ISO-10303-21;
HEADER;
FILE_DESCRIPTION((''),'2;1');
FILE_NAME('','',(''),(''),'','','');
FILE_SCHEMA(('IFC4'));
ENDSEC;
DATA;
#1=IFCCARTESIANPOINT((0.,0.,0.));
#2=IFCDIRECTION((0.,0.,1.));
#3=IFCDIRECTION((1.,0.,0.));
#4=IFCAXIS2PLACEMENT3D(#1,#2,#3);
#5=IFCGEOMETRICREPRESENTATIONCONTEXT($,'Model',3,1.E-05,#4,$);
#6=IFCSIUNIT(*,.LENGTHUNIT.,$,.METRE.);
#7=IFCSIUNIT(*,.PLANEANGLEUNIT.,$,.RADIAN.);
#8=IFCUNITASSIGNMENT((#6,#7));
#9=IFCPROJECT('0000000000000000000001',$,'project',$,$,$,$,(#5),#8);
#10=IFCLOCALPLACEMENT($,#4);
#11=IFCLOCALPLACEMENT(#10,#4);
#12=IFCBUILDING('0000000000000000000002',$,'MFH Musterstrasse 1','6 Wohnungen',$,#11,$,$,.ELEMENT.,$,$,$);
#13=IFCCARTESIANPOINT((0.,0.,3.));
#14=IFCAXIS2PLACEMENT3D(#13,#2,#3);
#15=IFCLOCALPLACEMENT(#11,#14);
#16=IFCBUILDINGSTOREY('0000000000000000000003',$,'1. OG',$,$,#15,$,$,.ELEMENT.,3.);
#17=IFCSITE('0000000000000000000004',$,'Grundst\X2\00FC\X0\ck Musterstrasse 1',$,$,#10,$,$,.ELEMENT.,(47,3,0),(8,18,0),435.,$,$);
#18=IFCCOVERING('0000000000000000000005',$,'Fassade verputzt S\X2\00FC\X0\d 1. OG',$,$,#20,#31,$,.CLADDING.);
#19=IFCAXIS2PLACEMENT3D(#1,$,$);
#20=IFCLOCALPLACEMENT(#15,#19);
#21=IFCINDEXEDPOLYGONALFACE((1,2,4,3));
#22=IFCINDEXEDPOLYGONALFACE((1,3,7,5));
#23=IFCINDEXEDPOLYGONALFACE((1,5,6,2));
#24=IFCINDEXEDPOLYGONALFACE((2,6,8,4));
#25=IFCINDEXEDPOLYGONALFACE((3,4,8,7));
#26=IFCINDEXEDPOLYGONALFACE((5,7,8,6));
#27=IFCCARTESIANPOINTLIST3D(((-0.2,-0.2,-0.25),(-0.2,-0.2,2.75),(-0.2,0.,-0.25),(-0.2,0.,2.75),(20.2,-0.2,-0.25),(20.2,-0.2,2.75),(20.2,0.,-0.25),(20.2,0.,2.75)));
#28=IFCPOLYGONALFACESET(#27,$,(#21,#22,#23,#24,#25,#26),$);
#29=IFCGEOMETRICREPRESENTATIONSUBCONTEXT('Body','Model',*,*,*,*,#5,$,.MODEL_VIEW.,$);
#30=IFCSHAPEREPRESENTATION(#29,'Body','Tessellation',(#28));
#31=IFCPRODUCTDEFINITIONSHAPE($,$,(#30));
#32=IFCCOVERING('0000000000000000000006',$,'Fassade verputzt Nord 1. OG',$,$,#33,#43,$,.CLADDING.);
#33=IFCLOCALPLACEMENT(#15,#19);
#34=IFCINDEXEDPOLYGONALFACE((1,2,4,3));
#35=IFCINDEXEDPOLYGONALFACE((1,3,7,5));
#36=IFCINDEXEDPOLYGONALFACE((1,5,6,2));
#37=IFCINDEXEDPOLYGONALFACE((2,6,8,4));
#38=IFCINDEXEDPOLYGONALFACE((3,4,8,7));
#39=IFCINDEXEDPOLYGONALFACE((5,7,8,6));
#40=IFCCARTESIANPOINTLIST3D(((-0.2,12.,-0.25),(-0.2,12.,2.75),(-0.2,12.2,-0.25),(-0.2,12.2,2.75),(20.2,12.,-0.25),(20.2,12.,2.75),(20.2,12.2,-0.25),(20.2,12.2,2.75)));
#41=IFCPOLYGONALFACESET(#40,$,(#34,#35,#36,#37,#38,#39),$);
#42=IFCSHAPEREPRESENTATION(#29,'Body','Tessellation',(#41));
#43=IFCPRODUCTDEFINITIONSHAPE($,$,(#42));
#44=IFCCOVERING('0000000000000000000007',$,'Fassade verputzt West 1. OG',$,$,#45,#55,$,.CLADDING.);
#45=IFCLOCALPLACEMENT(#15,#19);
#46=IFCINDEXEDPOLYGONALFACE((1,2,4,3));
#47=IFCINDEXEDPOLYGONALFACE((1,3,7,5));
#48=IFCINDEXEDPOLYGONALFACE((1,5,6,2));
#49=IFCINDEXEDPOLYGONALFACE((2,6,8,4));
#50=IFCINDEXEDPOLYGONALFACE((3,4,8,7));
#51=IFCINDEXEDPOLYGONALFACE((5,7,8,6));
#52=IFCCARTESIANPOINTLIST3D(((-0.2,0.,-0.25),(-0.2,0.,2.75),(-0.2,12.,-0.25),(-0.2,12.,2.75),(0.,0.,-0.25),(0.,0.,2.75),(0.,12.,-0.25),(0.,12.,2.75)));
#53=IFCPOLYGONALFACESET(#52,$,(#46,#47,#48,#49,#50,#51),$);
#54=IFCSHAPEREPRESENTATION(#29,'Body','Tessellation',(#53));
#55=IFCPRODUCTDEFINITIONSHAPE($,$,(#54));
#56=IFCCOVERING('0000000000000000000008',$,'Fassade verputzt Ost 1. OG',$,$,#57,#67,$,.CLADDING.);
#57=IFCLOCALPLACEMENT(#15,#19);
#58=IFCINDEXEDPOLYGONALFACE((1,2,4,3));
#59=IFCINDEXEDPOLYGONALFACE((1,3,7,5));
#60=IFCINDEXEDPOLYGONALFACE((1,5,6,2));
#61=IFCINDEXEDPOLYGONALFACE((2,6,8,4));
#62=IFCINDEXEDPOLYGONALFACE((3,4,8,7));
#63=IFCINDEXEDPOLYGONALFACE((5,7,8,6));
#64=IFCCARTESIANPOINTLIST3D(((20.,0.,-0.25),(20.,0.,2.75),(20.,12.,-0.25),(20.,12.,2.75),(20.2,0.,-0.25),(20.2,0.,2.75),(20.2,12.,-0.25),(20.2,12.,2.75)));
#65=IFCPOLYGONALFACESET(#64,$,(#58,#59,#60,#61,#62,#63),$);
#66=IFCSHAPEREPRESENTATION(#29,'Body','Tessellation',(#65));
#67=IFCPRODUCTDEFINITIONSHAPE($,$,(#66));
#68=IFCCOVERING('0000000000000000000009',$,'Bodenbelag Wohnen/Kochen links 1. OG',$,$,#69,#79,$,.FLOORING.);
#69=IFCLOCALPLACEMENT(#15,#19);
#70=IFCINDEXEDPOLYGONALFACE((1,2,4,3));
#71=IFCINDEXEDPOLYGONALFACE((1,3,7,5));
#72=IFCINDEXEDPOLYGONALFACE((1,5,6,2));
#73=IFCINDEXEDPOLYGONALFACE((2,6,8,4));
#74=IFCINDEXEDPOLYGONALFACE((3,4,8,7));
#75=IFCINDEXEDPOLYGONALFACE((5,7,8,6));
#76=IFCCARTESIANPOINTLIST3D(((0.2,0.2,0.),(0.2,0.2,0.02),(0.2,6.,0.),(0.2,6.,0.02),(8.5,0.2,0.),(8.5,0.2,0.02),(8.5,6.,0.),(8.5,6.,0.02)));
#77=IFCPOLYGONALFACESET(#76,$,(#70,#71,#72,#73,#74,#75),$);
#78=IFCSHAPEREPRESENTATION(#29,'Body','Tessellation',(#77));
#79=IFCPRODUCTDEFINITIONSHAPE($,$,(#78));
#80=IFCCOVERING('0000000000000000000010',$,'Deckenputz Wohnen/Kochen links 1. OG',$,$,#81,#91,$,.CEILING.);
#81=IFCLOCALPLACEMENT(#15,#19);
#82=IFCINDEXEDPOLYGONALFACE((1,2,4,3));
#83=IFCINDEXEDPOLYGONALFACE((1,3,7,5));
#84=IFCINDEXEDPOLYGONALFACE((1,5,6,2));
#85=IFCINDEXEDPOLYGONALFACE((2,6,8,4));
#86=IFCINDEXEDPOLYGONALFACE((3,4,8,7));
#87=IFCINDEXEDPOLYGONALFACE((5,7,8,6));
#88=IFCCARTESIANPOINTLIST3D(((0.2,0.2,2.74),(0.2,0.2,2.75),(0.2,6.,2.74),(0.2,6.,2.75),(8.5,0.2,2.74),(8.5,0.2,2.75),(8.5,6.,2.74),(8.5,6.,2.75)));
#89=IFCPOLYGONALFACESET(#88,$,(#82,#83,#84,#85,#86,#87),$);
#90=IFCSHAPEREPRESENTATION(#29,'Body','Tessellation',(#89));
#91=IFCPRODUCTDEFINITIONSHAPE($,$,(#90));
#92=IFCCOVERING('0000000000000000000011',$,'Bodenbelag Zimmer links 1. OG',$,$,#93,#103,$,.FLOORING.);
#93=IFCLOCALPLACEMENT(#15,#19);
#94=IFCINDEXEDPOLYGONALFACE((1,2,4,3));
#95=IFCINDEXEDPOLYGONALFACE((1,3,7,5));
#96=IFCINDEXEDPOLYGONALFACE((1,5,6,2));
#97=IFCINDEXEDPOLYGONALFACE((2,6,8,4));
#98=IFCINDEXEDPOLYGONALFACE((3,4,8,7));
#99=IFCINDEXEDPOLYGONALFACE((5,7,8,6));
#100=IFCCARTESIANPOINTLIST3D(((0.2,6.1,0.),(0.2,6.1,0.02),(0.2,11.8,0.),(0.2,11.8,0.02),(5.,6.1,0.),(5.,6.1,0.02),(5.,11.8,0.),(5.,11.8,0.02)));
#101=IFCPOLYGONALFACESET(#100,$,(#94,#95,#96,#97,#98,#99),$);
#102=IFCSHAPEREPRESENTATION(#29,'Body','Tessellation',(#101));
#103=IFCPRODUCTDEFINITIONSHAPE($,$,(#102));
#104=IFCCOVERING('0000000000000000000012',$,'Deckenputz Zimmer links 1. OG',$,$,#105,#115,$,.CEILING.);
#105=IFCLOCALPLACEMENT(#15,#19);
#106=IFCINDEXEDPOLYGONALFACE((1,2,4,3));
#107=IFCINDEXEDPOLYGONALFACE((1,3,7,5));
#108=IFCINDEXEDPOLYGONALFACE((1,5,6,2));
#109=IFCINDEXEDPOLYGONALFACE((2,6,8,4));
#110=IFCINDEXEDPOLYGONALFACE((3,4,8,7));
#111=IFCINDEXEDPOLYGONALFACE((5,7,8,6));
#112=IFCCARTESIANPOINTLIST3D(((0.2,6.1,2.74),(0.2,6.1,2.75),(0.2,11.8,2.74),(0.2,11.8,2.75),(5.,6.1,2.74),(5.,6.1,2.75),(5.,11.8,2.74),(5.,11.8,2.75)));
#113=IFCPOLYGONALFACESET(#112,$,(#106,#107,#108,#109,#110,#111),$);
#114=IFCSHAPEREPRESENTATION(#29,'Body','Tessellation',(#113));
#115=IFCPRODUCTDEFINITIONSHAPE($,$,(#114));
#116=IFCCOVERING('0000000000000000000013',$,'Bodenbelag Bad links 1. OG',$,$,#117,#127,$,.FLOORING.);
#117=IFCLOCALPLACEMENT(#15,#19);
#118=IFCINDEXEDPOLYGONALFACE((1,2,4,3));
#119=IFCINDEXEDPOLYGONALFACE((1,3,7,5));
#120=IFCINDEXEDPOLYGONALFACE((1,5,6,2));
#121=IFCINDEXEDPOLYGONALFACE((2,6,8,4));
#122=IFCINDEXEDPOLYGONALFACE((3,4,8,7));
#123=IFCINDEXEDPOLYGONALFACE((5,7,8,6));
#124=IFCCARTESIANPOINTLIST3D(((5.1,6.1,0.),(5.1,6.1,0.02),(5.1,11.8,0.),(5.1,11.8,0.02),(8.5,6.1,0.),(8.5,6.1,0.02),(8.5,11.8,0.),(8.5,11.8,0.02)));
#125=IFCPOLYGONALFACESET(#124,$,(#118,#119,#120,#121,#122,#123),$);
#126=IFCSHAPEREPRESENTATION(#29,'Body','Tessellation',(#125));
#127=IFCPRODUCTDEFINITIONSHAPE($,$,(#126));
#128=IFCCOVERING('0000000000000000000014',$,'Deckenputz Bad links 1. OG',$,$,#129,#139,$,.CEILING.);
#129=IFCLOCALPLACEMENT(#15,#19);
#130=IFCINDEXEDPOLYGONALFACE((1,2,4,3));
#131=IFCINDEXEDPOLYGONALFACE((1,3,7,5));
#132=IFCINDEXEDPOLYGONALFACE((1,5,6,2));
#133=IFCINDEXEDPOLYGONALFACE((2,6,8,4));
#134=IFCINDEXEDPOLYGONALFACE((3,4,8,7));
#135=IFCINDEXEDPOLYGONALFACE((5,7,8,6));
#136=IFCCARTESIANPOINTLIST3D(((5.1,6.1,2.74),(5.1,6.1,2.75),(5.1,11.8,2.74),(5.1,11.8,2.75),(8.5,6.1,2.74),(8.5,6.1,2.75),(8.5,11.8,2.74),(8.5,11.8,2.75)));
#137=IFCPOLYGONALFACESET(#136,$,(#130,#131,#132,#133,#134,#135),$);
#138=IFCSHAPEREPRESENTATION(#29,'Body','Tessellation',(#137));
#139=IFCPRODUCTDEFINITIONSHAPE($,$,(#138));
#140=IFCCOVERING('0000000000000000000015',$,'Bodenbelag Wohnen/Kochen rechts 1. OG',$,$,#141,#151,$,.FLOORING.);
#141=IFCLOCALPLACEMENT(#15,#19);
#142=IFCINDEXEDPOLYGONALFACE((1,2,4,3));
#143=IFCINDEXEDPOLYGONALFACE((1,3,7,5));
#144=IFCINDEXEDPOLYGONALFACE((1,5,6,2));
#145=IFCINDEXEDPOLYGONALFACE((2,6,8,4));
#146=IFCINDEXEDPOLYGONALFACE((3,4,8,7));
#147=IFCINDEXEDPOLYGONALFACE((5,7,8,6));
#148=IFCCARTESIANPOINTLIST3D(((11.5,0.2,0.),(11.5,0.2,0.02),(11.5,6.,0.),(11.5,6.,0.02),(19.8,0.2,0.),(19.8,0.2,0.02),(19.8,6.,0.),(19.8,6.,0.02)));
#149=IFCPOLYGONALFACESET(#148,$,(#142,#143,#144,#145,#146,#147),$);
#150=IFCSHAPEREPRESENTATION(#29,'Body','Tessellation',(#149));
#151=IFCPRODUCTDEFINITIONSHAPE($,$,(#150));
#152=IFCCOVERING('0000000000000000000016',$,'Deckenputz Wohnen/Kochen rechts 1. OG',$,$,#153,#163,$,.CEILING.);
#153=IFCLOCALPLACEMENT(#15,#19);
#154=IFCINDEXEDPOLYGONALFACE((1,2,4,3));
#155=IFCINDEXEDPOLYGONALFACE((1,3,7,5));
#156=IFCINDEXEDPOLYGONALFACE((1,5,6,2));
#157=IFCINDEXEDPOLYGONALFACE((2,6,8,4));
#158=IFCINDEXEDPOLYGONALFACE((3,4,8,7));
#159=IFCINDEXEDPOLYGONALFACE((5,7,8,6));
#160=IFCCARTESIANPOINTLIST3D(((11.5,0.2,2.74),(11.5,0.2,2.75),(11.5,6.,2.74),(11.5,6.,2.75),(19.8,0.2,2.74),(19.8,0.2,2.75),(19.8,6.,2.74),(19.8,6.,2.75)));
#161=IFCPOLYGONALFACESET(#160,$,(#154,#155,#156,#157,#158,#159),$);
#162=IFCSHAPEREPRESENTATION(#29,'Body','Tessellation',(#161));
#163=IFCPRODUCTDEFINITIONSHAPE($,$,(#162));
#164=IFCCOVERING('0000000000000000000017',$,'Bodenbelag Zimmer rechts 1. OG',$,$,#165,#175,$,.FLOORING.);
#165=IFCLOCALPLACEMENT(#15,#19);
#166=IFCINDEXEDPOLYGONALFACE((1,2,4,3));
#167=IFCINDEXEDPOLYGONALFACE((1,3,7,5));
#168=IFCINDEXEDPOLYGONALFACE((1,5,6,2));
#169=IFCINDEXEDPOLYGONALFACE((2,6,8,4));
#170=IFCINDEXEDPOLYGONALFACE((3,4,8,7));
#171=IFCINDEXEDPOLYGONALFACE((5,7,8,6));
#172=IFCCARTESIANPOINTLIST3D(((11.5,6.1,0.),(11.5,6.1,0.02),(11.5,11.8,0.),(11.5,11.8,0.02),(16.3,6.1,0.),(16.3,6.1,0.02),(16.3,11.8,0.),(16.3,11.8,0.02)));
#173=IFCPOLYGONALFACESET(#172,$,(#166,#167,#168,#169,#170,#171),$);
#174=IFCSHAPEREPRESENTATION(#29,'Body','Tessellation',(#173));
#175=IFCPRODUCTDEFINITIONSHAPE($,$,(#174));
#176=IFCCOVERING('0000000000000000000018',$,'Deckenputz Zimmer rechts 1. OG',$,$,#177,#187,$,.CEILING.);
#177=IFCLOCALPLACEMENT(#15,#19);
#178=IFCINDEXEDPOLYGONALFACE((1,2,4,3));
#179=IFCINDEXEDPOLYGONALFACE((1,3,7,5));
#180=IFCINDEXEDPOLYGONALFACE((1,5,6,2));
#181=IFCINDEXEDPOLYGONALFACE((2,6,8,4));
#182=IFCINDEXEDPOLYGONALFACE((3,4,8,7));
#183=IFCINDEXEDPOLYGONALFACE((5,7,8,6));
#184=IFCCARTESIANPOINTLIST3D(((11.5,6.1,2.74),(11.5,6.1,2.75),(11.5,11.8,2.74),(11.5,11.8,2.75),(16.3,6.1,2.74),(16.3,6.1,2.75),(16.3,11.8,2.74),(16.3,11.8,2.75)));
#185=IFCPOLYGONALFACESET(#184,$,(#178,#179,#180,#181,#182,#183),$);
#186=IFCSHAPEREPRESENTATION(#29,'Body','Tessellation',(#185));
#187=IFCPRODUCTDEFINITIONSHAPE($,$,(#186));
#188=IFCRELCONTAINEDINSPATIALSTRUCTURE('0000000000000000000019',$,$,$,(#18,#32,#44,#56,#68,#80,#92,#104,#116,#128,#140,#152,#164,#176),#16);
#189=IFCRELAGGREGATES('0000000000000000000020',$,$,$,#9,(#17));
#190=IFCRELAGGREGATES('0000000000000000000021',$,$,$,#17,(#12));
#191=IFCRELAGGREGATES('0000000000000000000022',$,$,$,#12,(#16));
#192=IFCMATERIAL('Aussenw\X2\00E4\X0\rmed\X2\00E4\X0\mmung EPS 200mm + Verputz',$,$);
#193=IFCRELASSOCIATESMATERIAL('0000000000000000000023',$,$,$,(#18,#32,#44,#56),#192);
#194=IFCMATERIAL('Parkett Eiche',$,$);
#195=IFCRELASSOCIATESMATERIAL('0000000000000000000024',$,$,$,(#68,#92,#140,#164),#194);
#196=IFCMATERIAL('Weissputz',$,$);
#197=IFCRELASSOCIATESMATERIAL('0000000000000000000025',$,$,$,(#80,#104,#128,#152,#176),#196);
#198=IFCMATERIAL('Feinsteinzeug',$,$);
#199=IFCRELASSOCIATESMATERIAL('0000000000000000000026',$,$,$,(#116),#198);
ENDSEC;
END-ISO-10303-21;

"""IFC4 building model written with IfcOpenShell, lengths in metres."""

from ifc_helpers import new_model, si_unit, frame, frame_2d, origin_with_axes, place, context, subcontext, project, spatial, rectangle, extrude, material, element, save


model = new_model("IFC4")

# Units and contexts
model_context = context("Model", 3, precision=1e-05, world=origin_with_axes())
body_context = subcontext(model_context, "Body", "Model", "MODEL_VIEW")
ifc_project = project(units=[si_unit("LENGTHUNIT", "METRE"), si_unit("PLANEANGLEUNIT", "RADIAN")], contexts=[model_context])

# Site, building, storey
site_placement = place(None, origin_with_axes())
site = spatial("IfcSite", under=ifc_project, at=site_placement, Name="Grundstück Musterstrasse 1", CompositionType="ELEMENT", RefLatitude=(47, 3, 0), RefLongitude=(8, 18, 0), RefElevation=435.0)
building_placement = place(site_placement, origin_with_axes())
building = spatial("IfcBuilding", under=site, at=building_placement, Name="MFH Musterstrasse 1", Description="6 Wohnungen", CompositionType="ELEMENT")
storey_placement = place(building_placement, frame((0.0, 0.0, 3.0), z_axis=(0.0, 0.0, 1.0), x_axis=(1.0, 0.0, 0.0)))
storey = spatial("IfcBuildingStorey", under=building, at=storey_placement, Name="1. OG", CompositionType="ELEMENT", Elevation=3.0)

# Coverings
ifc_material_1 = material(Name="Aussenwärmedämmung EPS 200mm + Verputz")
covering_1_placement = place(storey_placement, origin_with_axes())
element("IfcCovering", 1, at=covering_1_placement, inside=storey, material=ifc_material_1, Name="Fassade verputzt Süd 1. OG", PredefinedType="CLADDING", context=body_context, shape_type="SweptSolid", body=[
    extrude(rectangle(XDim=20.4, YDim=0.2, at=frame_2d((10.2, 0.1), x_axis=(1.0, 0.0))), frame((-0.2, -0.2, -0.25), z_axis=(0.0, 0.0, 1.0), x_axis=(1.0, 0.0, 0.0)), (0.0, 0.0, 1.0), 3.0),
])
covering_2_placement = place(storey_placement, origin_with_axes())
element("IfcCovering", 2, at=covering_2_placement, inside=storey, material=ifc_material_1, Name="Fassade verputzt Nord 1. OG", PredefinedType="CLADDING", context=body_context, shape_type="SweptSolid", body=[
    extrude(rectangle(XDim=20.4, YDim=0.2, at=frame_2d((10.2, 0.1), x_axis=(1.0, 0.0))), frame((-0.2, 12.0, -0.25), z_axis=(0.0, 0.0, 1.0), x_axis=(1.0, 0.0, 0.0)), (0.0, 0.0, 1.0), 3.0),
])
covering_3_placement = place(storey_placement, origin_with_axes())
element("IfcCovering", 3, at=covering_3_placement, inside=storey, material=ifc_material_1, Name="Fassade verputzt West 1. OG", PredefinedType="CLADDING", context=body_context, shape_type="SweptSolid", body=[
    extrude(rectangle(XDim=0.2, YDim=12.0, at=frame_2d((0.1, 6.0), x_axis=(1.0, 0.0))), frame((-0.2, 0.0, -0.25), z_axis=(0.0, 0.0, 1.0), x_axis=(1.0, 0.0, 0.0)), (0.0, 0.0, 1.0), 3.0),
])
covering_4_placement = place(storey_placement, origin_with_axes())
element("IfcCovering", 4, at=covering_4_placement, inside=storey, material=ifc_material_1, Name="Fassade verputzt Ost 1. OG", PredefinedType="CLADDING", context=body_context, shape_type="SweptSolid", body=[
    extrude(rectangle(XDim=0.2, YDim=12.0, at=frame_2d((0.1, 6.0), x_axis=(1.0, 0.0))), frame((20.0, 0.0, -0.25), z_axis=(0.0, 0.0, 1.0), x_axis=(1.0, 0.0, 0.0)), (0.0, 0.0, 1.0), 3.0),
])
ifc_material_2 = material(Name="Parkett Eiche")
covering_5_placement = place(storey_placement, origin_with_axes())
element("IfcCovering", 5, at=covering_5_placement, inside=storey, material=ifc_material_2, Name="Bodenbelag Wohnen/Kochen links 1. OG", PredefinedType="FLOORING", context=body_context, shape_type="SweptSolid", body=[
    extrude(rectangle(XDim=8.3, YDim=5.8, at=frame_2d((4.15, 2.9), x_axis=(1.0, 0.0))), frame((0.2, 0.2, 0.0), z_axis=(0.0, 0.0, 1.0), x_axis=(1.0, 0.0, 0.0)), (0.0, 0.0, 1.0), 0.02),
])
ifc_material_3 = material(Name="Weissputz")
covering_6_placement = place(storey_placement, origin_with_axes())
element("IfcCovering", 6, at=covering_6_placement, inside=storey, material=ifc_material_3, Name="Deckenputz Wohnen/Kochen links 1. OG", PredefinedType="CEILING", context=body_context, shape_type="SweptSolid", body=[
    extrude(rectangle(XDim=8.3, YDim=5.8, at=frame_2d((4.15, 2.9), x_axis=(1.0, 0.0))), frame((0.2, 0.2, 2.74), z_axis=(0.0, 0.0, 1.0), x_axis=(1.0, 0.0, 0.0)), (0.0, 0.0, 1.0), 0.01),
])
covering_7_placement = place(storey_placement, origin_with_axes())
element("IfcCovering", 7, at=covering_7_placement, inside=storey, material=ifc_material_2, Name="Bodenbelag Zimmer links 1. OG", PredefinedType="FLOORING", context=body_context, shape_type="SweptSolid", body=[
    extrude(rectangle(XDim=4.8, YDim=5.7, at=frame_2d((2.4, 2.85), x_axis=(1.0, 0.0))), frame((0.2, 6.1, 0.0), z_axis=(0.0, 0.0, 1.0), x_axis=(1.0, 0.0, 0.0)), (0.0, 0.0, 1.0), 0.02),
])
covering_8_placement = place(storey_placement, origin_with_axes())
element("IfcCovering", 8, at=covering_8_placement, inside=storey, material=ifc_material_3, Name="Deckenputz Zimmer links 1. OG", PredefinedType="CEILING", context=body_context, shape_type="SweptSolid", body=[
    extrude(rectangle(XDim=4.8, YDim=5.7, at=frame_2d((2.4, 2.85), x_axis=(1.0, 0.0))), frame((0.2, 6.1, 2.74), z_axis=(0.0, 0.0, 1.0), x_axis=(1.0, 0.0, 0.0)), (0.0, 0.0, 1.0), 0.01),
])
ifc_material_4 = material(Name="Feinsteinzeug")
covering_9_placement = place(storey_placement, origin_with_axes())
element("IfcCovering", 9, at=covering_9_placement, inside=storey, material=ifc_material_4, Name="Bodenbelag Bad links 1. OG", PredefinedType="FLOORING", context=body_context, shape_type="SweptSolid", body=[
    extrude(rectangle(XDim=3.4, YDim=5.7, at=frame_2d((1.7, 2.85), x_axis=(1.0, 0.0))), frame((5.1, 6.1, 0.0), z_axis=(0.0, 0.0, 1.0), x_axis=(1.0, 0.0, 0.0)), (0.0, 0.0, 1.0), 0.02),
])
covering_10_placement = place(storey_placement, origin_with_axes())
element("IfcCovering", 10, at=covering_10_placement, inside=storey, material=ifc_material_3, Name="Deckenputz Bad links 1. OG", PredefinedType="CEILING", context=body_context, shape_type="SweptSolid", body=[
    extrude(rectangle(XDim=3.4, YDim=5.7, at=frame_2d((1.7, 2.85), x_axis=(1.0, 0.0))), frame((5.1, 6.1, 2.74), z_axis=(0.0, 0.0, 1.0), x_axis=(1.0, 0.0, 0.0)), (0.0, 0.0, 1.0), 0.01),
])
covering_11_placement = place(storey_placement, origin_with_axes())
element("IfcCovering", 11, at=covering_11_placement, inside=storey, material=ifc_material_2, Name="Bodenbelag Wohnen/Kochen rechts 1. OG", PredefinedType="FLOORING", context=body_context, shape_type="SweptSolid", body=[
    extrude(rectangle(XDim=8.3, YDim=5.8, at=frame_2d((4.15, 2.9), x_axis=(1.0, 0.0))), frame((11.5, 0.2, 0.0), z_axis=(0.0, 0.0, 1.0), x_axis=(1.0, 0.0, 0.0)), (0.0, 0.0, 1.0), 0.02),
])
covering_12_placement = place(storey_placement, origin_with_axes())
element("IfcCovering", 12, at=covering_12_placement, inside=storey, material=ifc_material_3, Name="Deckenputz Wohnen/Kochen rechts 1. OG", PredefinedType="CEILING", context=body_context, shape_type="SweptSolid", body=[
    extrude(rectangle(XDim=8.3, YDim=5.8, at=frame_2d((4.15, 2.9), x_axis=(1.0, 0.0))), frame((11.5, 0.2, 2.74), z_axis=(0.0, 0.0, 1.0), x_axis=(1.0, 0.0, 0.0)), (0.0, 0.0, 1.0), 0.01),
])
covering_13_placement = place(storey_placement, origin_with_axes())
element("IfcCovering", 13, at=covering_13_placement, inside=storey, material=ifc_material_2, Name="Bodenbelag Zimmer rechts 1. OG", PredefinedType="FLOORING", context=body_context, shape_type="SweptSolid", body=[
    extrude(rectangle(XDim=4.8, YDim=5.7, at=frame_2d((2.4, 2.85), x_axis=(1.0, 0.0))), frame((11.5, 6.1, 0.0), z_axis=(0.0, 0.0, 1.0), x_axis=(1.0, 0.0, 0.0)), (0.0, 0.0, 1.0), 0.02),
])
covering_14_placement = place(storey_placement, origin_with_axes())
element("IfcCovering", 14, at=covering_14_placement, inside=storey, material=ifc_material_3, Name="Deckenputz Zimmer rechts 1. OG", PredefinedType="CEILING", context=body_context, shape_type="SweptSolid", body=[
    extrude(rectangle(XDim=4.8, YDim=5.7, at=frame_2d((2.4, 2.85), x_axis=(1.0, 0.0))), frame((11.5, 6.1, 2.74), z_axis=(0.0, 0.0, 1.0), x_axis=(1.0, 0.0, 0.0)), (0.0, 0.0, 1.0), 0.01),
])

save(model, "model.ifc")
